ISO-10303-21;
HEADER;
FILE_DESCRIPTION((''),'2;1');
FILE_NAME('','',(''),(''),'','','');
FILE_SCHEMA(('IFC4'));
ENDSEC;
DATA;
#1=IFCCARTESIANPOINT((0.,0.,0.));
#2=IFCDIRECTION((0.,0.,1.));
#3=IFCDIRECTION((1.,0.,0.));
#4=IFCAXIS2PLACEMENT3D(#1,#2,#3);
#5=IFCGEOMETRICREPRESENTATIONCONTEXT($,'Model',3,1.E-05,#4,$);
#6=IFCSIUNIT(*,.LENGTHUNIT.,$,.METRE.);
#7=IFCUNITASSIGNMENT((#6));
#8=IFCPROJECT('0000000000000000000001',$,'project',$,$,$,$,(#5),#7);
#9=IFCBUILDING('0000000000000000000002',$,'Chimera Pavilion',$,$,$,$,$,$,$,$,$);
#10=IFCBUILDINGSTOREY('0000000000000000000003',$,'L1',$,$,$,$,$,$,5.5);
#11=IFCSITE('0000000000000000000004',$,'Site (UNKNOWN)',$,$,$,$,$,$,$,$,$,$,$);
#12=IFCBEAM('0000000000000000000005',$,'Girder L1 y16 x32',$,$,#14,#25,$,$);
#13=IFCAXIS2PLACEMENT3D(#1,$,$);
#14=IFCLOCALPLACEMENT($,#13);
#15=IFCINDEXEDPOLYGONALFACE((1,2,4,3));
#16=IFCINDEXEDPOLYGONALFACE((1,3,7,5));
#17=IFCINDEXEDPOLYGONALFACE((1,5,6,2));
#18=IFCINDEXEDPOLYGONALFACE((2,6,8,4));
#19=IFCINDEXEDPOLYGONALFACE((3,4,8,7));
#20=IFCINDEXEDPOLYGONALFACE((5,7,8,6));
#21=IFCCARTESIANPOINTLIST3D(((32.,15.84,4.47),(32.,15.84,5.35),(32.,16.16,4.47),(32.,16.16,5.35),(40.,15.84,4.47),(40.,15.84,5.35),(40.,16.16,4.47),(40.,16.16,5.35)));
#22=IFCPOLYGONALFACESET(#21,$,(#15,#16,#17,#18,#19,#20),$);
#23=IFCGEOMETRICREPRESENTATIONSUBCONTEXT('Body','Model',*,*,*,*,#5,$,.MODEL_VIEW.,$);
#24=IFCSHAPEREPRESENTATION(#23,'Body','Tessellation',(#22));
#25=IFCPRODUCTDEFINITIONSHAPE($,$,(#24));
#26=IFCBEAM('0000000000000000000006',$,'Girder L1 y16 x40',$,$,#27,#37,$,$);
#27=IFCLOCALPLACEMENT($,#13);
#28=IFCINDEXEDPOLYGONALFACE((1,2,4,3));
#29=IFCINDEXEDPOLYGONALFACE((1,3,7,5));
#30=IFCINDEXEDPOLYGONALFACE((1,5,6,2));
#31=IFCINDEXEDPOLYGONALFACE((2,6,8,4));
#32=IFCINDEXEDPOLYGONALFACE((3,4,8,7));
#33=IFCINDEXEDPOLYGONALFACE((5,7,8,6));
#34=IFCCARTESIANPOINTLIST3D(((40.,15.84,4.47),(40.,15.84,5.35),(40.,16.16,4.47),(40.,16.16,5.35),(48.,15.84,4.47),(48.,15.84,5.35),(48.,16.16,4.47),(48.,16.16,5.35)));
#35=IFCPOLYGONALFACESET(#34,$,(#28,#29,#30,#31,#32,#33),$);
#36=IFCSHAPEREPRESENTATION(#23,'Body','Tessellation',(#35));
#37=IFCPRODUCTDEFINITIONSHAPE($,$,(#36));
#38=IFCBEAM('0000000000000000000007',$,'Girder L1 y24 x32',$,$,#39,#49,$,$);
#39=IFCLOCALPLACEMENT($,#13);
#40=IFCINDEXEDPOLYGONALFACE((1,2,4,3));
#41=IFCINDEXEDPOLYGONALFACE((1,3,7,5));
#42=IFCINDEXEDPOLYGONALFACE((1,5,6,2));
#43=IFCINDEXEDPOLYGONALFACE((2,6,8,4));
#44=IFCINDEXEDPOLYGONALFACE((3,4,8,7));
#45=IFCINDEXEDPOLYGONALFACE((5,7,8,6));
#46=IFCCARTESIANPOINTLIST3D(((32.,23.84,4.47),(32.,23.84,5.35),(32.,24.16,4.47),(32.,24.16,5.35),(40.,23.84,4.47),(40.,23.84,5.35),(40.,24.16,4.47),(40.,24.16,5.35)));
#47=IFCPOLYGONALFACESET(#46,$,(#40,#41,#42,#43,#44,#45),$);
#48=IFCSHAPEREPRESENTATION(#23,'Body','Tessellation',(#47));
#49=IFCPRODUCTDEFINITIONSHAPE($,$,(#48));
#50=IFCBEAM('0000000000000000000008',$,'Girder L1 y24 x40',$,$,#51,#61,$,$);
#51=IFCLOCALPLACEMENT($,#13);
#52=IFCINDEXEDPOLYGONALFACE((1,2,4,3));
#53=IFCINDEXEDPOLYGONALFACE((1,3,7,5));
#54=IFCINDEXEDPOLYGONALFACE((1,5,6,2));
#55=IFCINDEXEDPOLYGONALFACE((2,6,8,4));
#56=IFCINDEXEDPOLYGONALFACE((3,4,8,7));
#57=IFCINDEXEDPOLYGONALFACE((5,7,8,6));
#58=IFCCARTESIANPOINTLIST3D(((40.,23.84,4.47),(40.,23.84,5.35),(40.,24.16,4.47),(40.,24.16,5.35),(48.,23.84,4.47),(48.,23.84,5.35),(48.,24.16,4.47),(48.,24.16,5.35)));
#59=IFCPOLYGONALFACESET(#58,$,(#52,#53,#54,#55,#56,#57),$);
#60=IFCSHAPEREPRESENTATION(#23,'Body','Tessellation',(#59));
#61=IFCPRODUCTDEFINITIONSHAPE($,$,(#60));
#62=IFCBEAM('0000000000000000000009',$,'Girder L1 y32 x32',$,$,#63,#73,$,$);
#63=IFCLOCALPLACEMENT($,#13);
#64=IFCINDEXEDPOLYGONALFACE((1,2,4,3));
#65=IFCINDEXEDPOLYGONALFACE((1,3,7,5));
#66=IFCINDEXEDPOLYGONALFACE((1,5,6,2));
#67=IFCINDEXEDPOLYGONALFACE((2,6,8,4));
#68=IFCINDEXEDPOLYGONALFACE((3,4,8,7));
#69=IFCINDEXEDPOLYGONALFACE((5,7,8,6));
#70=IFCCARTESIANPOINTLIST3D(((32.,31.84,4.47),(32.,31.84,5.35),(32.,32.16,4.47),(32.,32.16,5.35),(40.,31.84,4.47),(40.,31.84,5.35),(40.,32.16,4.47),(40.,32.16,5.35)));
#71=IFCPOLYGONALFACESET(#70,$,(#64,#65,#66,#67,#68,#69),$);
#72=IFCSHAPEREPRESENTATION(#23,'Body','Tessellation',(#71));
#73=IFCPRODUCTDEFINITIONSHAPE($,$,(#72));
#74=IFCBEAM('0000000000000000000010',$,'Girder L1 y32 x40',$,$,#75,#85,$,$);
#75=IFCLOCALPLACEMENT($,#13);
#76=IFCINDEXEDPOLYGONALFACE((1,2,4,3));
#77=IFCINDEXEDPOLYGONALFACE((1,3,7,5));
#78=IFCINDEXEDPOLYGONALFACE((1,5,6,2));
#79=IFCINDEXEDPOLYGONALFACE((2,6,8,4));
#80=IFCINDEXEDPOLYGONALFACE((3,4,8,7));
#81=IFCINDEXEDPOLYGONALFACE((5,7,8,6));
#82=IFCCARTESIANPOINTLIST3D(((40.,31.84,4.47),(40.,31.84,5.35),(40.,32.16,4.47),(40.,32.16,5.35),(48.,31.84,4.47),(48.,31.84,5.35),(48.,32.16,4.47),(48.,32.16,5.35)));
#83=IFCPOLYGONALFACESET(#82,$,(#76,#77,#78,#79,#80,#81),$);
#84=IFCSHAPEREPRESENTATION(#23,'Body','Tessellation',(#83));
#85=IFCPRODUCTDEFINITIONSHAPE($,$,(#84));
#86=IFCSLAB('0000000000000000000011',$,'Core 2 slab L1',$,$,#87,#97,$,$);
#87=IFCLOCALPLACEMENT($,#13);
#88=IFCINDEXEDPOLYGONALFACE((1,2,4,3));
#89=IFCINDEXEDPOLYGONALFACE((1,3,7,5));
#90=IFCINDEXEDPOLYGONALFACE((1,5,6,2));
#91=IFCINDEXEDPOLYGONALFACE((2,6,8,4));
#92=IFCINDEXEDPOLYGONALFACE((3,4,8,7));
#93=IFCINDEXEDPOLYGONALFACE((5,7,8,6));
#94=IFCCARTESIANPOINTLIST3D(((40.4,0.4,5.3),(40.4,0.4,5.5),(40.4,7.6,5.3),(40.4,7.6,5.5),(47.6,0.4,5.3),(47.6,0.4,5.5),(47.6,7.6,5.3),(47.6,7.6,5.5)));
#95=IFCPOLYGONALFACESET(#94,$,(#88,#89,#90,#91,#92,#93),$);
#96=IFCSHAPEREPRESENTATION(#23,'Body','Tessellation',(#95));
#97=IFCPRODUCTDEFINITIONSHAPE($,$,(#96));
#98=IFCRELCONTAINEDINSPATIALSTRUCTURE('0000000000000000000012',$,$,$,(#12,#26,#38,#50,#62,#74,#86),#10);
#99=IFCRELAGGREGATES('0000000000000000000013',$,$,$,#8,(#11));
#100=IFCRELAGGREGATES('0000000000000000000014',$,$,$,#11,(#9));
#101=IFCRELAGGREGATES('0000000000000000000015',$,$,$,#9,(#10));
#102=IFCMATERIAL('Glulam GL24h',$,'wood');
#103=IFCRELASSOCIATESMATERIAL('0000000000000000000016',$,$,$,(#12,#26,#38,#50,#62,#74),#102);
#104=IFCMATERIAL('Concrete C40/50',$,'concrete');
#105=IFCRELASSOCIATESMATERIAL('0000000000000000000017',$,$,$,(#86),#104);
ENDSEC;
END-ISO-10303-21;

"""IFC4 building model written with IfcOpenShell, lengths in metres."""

from ifc_helpers import new_model, si_unit, frame, origin_with_axes, place, context, subcontext, project, spatial, rectangle, extrude, material, element, save


model = new_model("IFC4")

# Units and contexts
model_context = context("Model", 3, precision=1e-05, world=origin_with_axes())
body_context = subcontext(model_context, "Body", "Model", "MODEL_VIEW")
ifc_project = project(units=[si_unit("LENGTHUNIT", "METRE")], contexts=[model_context])

# Site, building, storey
site = spatial("IfcSite", under=ifc_project, Name="Site (UNKNOWN)")
building = spatial("IfcBuilding", under=site, Name="Chimera Pavilion")
storey = spatial("IfcBuildingStorey", under=building, Name="L1", Elevation=5.5)

# Beams
ifc_material_1 = material(Name="Glulam GL24h", Category="wood")
for number, where, z_axis, x_axis, name in (
    (1, (32.0, 16.0, 4.91), (1.0, 0.0, 0.0), (0.0, -1.0, 0.0), "Girder L1 y16 x32"),
    (2, (40.0, 16.0, 4.91), (1.0, 0.0, 0.0), (0.0, -1.0, 0.0), "Girder L1 y16 x40"),
    (3, (32.0, 24.0, 4.91), (1.0, 0.0, 0.0), (0.0, -1.0, 0.0), "Girder L1 y24 x32"),
    (4, (40.0, 24.0, 4.91), (1.0, 0.0, 0.0), (0.0, -1.0, 0.0), "Girder L1 y24 x40"),
    (5, (32.0, 32.0, 4.91), (1.0, 0.0, 0.0), (0.0, -1.0, 0.0), "Girder L1 y32 x32"),
    (6, (40.0, 32.0, 4.91), (1.0, 0.0, 0.0), (0.0, -1.0, 0.0), "Girder L1 y32 x40"),
):
    element("IfcBeam", number, at=place(None, frame(where, z_axis=z_axis, x_axis=x_axis)), inside=storey, material=ifc_material_1, Name=name, context=body_context, shape_type="SweptSolid", body=[
        extrude(rectangle(XDim=0.32, YDim=0.88), origin_with_axes(), (0.0, 0.0, 1.0), 8.0),
    ])

# Slab
ifc_material_2 = material(Name="Concrete C40/50", Category="concrete")
slab_placement = place(None, frame((44.0, 4.0, 5.3), z_axis=(0.0, 0.0, 1.0), x_axis=(1.0, 0.0, 0.0)))
element("IfcSlab", 7, at=slab_placement, inside=storey, material=ifc_material_2, Name="Core 2 slab L1", context=body_context, shape_type="SweptSolid", body=[
    extrude(rectangle(XDim=7.2, YDim=7.2), origin_with_axes(), (0.0, 0.0, 1.0), 0.2),
])

save(model, "model.ifc")
